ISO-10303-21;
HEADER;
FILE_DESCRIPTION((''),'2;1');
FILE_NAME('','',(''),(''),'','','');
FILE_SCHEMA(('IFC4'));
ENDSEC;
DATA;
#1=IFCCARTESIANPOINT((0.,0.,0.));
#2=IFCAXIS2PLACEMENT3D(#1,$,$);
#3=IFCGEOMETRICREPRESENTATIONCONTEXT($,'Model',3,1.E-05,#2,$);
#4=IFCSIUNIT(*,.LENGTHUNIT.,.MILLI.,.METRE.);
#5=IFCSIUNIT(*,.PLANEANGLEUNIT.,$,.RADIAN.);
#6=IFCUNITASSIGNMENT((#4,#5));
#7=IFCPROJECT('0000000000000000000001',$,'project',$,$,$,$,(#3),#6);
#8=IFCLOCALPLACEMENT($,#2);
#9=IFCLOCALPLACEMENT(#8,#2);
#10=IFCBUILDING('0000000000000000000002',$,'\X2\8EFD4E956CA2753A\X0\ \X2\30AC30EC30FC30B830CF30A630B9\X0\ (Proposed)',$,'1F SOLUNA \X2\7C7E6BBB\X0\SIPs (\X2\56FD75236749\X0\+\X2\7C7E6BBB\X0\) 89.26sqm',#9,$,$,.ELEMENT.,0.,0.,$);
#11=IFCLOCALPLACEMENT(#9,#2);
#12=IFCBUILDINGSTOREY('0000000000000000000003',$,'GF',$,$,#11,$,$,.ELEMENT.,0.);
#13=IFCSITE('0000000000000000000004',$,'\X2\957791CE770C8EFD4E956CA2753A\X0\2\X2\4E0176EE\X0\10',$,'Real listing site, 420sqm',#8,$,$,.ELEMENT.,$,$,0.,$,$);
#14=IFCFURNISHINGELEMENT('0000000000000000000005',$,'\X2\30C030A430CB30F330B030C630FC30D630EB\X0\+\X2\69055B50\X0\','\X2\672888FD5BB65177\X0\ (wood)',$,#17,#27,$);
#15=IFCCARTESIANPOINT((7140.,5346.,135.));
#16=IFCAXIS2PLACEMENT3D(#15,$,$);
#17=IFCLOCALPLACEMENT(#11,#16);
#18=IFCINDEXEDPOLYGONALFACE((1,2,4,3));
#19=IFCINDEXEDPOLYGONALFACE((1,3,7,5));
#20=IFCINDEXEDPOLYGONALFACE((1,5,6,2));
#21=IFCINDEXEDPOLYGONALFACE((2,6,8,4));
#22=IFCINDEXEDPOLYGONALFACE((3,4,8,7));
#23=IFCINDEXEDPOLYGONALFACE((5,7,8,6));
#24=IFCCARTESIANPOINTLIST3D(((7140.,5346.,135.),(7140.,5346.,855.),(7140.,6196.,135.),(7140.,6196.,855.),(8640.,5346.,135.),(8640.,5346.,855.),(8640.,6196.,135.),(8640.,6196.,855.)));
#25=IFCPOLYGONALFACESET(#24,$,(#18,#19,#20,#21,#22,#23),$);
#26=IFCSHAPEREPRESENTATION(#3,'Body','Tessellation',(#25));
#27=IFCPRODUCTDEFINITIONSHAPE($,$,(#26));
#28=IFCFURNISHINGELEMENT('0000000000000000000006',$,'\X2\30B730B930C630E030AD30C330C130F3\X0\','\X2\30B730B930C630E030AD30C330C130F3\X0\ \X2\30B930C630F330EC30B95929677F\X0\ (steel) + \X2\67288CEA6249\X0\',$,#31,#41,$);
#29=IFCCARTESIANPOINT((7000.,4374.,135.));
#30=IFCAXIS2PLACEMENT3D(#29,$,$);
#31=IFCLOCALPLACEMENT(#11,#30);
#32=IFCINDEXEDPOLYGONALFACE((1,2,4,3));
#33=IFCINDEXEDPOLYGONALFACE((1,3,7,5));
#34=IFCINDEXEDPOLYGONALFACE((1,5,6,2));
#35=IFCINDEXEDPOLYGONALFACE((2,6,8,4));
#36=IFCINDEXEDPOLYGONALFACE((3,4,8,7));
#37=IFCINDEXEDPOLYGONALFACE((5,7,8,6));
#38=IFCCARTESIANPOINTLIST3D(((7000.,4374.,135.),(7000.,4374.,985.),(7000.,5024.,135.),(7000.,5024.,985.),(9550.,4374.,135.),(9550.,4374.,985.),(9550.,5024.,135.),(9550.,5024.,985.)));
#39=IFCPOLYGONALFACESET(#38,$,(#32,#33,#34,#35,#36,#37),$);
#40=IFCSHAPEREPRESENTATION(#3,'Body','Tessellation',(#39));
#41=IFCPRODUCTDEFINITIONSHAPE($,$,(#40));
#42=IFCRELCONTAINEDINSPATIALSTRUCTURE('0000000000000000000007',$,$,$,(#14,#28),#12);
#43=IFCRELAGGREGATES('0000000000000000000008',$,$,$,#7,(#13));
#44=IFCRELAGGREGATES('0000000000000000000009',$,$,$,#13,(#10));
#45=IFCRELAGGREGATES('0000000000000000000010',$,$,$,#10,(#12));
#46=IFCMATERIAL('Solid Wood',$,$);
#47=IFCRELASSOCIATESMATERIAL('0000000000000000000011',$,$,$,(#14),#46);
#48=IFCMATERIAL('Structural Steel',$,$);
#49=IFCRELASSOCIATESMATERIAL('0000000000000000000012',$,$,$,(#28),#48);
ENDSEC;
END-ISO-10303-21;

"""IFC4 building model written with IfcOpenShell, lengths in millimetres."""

from ifc_helpers import new_model, si_unit, frame, frame_2d, origin, place, context, project, spatial, rectangle, extrude, material, element, save


model = new_model("IFC4")

# Units and contexts
model_context = context("Model", 3, precision=1e-05, world=origin())
ifc_project = project(units=[si_unit("LENGTHUNIT", "METRE", prefix="MILLI"), si_unit("PLANEANGLEUNIT", "RADIAN")], contexts=[model_context])

# Site, building, storey
site_placement = place(None, origin())
site = spatial("IfcSite", under=ifc_project, at=site_placement, Name="長野県軽井沢町2丁目10", ObjectType="Real listing site, 420sqm", CompositionType="ELEMENT", RefElevation=0.0)
building_placement = place(site_placement, origin())
building = spatial("IfcBuilding", under=site, at=building_placement, Name="軽井沢町 ガレージハウス (Proposed)", ObjectType="1F SOLUNA 籾殻SIPs (国産杉+籾殻) 89.26sqm", CompositionType="ELEMENT", ElevationOfRefHeight=0.0, ElevationOfTerrain=0.0)
storey_placement = place(building_placement, origin())
storey = spatial("IfcBuildingStorey", under=building, at=storey_placement, Name="GF", CompositionType="ELEMENT", Elevation=0.0)

# Shared definitions
ifc_material_1 = material(Name="Solid Wood")

# Shared definitions
ifc_material_2 = material(Name="Structural Steel")

# Furnishing elements
furnishing_1_placement = place(storey_placement, frame((7140.0, 5346.0, 135.0)))
element("IfcFurnishingElement", 1, at=furnishing_1_placement, inside=storey, material=ifc_material_1, Name="ダイニングテーブル+椅子", Description="木製家具 (wood)", context=model_context, shape_type="SweptSolid", body=[
    extrude(rectangle(XDim=1500.0, YDim=850.0, at=frame_2d((750.0, 425.0))), frame((7140.0, 5346.0, 135.0)), (0.0, 0.0, 1.0), 720.0),
])
furnishing_2_placement = place(storey_placement, frame((7000.0, 4374.0, 135.0)))
element("IfcFurnishingElement", 2, at=furnishing_2_placement, inside=storey, material=ifc_material_2, Name="システムキッチン", Description="システムキッチン ステンレス天板 (steel) + 木質扉", context=model_context, shape_type="SweptSolid", body=[
    extrude(rectangle(XDim=2550.0, YDim=650.0, at=frame_2d((1275.0, 325.0))), frame((7000.0, 4374.0, 135.0)), (0.0, 0.0, 1.0), 850.0),
])

save(model, "model.ifc")
